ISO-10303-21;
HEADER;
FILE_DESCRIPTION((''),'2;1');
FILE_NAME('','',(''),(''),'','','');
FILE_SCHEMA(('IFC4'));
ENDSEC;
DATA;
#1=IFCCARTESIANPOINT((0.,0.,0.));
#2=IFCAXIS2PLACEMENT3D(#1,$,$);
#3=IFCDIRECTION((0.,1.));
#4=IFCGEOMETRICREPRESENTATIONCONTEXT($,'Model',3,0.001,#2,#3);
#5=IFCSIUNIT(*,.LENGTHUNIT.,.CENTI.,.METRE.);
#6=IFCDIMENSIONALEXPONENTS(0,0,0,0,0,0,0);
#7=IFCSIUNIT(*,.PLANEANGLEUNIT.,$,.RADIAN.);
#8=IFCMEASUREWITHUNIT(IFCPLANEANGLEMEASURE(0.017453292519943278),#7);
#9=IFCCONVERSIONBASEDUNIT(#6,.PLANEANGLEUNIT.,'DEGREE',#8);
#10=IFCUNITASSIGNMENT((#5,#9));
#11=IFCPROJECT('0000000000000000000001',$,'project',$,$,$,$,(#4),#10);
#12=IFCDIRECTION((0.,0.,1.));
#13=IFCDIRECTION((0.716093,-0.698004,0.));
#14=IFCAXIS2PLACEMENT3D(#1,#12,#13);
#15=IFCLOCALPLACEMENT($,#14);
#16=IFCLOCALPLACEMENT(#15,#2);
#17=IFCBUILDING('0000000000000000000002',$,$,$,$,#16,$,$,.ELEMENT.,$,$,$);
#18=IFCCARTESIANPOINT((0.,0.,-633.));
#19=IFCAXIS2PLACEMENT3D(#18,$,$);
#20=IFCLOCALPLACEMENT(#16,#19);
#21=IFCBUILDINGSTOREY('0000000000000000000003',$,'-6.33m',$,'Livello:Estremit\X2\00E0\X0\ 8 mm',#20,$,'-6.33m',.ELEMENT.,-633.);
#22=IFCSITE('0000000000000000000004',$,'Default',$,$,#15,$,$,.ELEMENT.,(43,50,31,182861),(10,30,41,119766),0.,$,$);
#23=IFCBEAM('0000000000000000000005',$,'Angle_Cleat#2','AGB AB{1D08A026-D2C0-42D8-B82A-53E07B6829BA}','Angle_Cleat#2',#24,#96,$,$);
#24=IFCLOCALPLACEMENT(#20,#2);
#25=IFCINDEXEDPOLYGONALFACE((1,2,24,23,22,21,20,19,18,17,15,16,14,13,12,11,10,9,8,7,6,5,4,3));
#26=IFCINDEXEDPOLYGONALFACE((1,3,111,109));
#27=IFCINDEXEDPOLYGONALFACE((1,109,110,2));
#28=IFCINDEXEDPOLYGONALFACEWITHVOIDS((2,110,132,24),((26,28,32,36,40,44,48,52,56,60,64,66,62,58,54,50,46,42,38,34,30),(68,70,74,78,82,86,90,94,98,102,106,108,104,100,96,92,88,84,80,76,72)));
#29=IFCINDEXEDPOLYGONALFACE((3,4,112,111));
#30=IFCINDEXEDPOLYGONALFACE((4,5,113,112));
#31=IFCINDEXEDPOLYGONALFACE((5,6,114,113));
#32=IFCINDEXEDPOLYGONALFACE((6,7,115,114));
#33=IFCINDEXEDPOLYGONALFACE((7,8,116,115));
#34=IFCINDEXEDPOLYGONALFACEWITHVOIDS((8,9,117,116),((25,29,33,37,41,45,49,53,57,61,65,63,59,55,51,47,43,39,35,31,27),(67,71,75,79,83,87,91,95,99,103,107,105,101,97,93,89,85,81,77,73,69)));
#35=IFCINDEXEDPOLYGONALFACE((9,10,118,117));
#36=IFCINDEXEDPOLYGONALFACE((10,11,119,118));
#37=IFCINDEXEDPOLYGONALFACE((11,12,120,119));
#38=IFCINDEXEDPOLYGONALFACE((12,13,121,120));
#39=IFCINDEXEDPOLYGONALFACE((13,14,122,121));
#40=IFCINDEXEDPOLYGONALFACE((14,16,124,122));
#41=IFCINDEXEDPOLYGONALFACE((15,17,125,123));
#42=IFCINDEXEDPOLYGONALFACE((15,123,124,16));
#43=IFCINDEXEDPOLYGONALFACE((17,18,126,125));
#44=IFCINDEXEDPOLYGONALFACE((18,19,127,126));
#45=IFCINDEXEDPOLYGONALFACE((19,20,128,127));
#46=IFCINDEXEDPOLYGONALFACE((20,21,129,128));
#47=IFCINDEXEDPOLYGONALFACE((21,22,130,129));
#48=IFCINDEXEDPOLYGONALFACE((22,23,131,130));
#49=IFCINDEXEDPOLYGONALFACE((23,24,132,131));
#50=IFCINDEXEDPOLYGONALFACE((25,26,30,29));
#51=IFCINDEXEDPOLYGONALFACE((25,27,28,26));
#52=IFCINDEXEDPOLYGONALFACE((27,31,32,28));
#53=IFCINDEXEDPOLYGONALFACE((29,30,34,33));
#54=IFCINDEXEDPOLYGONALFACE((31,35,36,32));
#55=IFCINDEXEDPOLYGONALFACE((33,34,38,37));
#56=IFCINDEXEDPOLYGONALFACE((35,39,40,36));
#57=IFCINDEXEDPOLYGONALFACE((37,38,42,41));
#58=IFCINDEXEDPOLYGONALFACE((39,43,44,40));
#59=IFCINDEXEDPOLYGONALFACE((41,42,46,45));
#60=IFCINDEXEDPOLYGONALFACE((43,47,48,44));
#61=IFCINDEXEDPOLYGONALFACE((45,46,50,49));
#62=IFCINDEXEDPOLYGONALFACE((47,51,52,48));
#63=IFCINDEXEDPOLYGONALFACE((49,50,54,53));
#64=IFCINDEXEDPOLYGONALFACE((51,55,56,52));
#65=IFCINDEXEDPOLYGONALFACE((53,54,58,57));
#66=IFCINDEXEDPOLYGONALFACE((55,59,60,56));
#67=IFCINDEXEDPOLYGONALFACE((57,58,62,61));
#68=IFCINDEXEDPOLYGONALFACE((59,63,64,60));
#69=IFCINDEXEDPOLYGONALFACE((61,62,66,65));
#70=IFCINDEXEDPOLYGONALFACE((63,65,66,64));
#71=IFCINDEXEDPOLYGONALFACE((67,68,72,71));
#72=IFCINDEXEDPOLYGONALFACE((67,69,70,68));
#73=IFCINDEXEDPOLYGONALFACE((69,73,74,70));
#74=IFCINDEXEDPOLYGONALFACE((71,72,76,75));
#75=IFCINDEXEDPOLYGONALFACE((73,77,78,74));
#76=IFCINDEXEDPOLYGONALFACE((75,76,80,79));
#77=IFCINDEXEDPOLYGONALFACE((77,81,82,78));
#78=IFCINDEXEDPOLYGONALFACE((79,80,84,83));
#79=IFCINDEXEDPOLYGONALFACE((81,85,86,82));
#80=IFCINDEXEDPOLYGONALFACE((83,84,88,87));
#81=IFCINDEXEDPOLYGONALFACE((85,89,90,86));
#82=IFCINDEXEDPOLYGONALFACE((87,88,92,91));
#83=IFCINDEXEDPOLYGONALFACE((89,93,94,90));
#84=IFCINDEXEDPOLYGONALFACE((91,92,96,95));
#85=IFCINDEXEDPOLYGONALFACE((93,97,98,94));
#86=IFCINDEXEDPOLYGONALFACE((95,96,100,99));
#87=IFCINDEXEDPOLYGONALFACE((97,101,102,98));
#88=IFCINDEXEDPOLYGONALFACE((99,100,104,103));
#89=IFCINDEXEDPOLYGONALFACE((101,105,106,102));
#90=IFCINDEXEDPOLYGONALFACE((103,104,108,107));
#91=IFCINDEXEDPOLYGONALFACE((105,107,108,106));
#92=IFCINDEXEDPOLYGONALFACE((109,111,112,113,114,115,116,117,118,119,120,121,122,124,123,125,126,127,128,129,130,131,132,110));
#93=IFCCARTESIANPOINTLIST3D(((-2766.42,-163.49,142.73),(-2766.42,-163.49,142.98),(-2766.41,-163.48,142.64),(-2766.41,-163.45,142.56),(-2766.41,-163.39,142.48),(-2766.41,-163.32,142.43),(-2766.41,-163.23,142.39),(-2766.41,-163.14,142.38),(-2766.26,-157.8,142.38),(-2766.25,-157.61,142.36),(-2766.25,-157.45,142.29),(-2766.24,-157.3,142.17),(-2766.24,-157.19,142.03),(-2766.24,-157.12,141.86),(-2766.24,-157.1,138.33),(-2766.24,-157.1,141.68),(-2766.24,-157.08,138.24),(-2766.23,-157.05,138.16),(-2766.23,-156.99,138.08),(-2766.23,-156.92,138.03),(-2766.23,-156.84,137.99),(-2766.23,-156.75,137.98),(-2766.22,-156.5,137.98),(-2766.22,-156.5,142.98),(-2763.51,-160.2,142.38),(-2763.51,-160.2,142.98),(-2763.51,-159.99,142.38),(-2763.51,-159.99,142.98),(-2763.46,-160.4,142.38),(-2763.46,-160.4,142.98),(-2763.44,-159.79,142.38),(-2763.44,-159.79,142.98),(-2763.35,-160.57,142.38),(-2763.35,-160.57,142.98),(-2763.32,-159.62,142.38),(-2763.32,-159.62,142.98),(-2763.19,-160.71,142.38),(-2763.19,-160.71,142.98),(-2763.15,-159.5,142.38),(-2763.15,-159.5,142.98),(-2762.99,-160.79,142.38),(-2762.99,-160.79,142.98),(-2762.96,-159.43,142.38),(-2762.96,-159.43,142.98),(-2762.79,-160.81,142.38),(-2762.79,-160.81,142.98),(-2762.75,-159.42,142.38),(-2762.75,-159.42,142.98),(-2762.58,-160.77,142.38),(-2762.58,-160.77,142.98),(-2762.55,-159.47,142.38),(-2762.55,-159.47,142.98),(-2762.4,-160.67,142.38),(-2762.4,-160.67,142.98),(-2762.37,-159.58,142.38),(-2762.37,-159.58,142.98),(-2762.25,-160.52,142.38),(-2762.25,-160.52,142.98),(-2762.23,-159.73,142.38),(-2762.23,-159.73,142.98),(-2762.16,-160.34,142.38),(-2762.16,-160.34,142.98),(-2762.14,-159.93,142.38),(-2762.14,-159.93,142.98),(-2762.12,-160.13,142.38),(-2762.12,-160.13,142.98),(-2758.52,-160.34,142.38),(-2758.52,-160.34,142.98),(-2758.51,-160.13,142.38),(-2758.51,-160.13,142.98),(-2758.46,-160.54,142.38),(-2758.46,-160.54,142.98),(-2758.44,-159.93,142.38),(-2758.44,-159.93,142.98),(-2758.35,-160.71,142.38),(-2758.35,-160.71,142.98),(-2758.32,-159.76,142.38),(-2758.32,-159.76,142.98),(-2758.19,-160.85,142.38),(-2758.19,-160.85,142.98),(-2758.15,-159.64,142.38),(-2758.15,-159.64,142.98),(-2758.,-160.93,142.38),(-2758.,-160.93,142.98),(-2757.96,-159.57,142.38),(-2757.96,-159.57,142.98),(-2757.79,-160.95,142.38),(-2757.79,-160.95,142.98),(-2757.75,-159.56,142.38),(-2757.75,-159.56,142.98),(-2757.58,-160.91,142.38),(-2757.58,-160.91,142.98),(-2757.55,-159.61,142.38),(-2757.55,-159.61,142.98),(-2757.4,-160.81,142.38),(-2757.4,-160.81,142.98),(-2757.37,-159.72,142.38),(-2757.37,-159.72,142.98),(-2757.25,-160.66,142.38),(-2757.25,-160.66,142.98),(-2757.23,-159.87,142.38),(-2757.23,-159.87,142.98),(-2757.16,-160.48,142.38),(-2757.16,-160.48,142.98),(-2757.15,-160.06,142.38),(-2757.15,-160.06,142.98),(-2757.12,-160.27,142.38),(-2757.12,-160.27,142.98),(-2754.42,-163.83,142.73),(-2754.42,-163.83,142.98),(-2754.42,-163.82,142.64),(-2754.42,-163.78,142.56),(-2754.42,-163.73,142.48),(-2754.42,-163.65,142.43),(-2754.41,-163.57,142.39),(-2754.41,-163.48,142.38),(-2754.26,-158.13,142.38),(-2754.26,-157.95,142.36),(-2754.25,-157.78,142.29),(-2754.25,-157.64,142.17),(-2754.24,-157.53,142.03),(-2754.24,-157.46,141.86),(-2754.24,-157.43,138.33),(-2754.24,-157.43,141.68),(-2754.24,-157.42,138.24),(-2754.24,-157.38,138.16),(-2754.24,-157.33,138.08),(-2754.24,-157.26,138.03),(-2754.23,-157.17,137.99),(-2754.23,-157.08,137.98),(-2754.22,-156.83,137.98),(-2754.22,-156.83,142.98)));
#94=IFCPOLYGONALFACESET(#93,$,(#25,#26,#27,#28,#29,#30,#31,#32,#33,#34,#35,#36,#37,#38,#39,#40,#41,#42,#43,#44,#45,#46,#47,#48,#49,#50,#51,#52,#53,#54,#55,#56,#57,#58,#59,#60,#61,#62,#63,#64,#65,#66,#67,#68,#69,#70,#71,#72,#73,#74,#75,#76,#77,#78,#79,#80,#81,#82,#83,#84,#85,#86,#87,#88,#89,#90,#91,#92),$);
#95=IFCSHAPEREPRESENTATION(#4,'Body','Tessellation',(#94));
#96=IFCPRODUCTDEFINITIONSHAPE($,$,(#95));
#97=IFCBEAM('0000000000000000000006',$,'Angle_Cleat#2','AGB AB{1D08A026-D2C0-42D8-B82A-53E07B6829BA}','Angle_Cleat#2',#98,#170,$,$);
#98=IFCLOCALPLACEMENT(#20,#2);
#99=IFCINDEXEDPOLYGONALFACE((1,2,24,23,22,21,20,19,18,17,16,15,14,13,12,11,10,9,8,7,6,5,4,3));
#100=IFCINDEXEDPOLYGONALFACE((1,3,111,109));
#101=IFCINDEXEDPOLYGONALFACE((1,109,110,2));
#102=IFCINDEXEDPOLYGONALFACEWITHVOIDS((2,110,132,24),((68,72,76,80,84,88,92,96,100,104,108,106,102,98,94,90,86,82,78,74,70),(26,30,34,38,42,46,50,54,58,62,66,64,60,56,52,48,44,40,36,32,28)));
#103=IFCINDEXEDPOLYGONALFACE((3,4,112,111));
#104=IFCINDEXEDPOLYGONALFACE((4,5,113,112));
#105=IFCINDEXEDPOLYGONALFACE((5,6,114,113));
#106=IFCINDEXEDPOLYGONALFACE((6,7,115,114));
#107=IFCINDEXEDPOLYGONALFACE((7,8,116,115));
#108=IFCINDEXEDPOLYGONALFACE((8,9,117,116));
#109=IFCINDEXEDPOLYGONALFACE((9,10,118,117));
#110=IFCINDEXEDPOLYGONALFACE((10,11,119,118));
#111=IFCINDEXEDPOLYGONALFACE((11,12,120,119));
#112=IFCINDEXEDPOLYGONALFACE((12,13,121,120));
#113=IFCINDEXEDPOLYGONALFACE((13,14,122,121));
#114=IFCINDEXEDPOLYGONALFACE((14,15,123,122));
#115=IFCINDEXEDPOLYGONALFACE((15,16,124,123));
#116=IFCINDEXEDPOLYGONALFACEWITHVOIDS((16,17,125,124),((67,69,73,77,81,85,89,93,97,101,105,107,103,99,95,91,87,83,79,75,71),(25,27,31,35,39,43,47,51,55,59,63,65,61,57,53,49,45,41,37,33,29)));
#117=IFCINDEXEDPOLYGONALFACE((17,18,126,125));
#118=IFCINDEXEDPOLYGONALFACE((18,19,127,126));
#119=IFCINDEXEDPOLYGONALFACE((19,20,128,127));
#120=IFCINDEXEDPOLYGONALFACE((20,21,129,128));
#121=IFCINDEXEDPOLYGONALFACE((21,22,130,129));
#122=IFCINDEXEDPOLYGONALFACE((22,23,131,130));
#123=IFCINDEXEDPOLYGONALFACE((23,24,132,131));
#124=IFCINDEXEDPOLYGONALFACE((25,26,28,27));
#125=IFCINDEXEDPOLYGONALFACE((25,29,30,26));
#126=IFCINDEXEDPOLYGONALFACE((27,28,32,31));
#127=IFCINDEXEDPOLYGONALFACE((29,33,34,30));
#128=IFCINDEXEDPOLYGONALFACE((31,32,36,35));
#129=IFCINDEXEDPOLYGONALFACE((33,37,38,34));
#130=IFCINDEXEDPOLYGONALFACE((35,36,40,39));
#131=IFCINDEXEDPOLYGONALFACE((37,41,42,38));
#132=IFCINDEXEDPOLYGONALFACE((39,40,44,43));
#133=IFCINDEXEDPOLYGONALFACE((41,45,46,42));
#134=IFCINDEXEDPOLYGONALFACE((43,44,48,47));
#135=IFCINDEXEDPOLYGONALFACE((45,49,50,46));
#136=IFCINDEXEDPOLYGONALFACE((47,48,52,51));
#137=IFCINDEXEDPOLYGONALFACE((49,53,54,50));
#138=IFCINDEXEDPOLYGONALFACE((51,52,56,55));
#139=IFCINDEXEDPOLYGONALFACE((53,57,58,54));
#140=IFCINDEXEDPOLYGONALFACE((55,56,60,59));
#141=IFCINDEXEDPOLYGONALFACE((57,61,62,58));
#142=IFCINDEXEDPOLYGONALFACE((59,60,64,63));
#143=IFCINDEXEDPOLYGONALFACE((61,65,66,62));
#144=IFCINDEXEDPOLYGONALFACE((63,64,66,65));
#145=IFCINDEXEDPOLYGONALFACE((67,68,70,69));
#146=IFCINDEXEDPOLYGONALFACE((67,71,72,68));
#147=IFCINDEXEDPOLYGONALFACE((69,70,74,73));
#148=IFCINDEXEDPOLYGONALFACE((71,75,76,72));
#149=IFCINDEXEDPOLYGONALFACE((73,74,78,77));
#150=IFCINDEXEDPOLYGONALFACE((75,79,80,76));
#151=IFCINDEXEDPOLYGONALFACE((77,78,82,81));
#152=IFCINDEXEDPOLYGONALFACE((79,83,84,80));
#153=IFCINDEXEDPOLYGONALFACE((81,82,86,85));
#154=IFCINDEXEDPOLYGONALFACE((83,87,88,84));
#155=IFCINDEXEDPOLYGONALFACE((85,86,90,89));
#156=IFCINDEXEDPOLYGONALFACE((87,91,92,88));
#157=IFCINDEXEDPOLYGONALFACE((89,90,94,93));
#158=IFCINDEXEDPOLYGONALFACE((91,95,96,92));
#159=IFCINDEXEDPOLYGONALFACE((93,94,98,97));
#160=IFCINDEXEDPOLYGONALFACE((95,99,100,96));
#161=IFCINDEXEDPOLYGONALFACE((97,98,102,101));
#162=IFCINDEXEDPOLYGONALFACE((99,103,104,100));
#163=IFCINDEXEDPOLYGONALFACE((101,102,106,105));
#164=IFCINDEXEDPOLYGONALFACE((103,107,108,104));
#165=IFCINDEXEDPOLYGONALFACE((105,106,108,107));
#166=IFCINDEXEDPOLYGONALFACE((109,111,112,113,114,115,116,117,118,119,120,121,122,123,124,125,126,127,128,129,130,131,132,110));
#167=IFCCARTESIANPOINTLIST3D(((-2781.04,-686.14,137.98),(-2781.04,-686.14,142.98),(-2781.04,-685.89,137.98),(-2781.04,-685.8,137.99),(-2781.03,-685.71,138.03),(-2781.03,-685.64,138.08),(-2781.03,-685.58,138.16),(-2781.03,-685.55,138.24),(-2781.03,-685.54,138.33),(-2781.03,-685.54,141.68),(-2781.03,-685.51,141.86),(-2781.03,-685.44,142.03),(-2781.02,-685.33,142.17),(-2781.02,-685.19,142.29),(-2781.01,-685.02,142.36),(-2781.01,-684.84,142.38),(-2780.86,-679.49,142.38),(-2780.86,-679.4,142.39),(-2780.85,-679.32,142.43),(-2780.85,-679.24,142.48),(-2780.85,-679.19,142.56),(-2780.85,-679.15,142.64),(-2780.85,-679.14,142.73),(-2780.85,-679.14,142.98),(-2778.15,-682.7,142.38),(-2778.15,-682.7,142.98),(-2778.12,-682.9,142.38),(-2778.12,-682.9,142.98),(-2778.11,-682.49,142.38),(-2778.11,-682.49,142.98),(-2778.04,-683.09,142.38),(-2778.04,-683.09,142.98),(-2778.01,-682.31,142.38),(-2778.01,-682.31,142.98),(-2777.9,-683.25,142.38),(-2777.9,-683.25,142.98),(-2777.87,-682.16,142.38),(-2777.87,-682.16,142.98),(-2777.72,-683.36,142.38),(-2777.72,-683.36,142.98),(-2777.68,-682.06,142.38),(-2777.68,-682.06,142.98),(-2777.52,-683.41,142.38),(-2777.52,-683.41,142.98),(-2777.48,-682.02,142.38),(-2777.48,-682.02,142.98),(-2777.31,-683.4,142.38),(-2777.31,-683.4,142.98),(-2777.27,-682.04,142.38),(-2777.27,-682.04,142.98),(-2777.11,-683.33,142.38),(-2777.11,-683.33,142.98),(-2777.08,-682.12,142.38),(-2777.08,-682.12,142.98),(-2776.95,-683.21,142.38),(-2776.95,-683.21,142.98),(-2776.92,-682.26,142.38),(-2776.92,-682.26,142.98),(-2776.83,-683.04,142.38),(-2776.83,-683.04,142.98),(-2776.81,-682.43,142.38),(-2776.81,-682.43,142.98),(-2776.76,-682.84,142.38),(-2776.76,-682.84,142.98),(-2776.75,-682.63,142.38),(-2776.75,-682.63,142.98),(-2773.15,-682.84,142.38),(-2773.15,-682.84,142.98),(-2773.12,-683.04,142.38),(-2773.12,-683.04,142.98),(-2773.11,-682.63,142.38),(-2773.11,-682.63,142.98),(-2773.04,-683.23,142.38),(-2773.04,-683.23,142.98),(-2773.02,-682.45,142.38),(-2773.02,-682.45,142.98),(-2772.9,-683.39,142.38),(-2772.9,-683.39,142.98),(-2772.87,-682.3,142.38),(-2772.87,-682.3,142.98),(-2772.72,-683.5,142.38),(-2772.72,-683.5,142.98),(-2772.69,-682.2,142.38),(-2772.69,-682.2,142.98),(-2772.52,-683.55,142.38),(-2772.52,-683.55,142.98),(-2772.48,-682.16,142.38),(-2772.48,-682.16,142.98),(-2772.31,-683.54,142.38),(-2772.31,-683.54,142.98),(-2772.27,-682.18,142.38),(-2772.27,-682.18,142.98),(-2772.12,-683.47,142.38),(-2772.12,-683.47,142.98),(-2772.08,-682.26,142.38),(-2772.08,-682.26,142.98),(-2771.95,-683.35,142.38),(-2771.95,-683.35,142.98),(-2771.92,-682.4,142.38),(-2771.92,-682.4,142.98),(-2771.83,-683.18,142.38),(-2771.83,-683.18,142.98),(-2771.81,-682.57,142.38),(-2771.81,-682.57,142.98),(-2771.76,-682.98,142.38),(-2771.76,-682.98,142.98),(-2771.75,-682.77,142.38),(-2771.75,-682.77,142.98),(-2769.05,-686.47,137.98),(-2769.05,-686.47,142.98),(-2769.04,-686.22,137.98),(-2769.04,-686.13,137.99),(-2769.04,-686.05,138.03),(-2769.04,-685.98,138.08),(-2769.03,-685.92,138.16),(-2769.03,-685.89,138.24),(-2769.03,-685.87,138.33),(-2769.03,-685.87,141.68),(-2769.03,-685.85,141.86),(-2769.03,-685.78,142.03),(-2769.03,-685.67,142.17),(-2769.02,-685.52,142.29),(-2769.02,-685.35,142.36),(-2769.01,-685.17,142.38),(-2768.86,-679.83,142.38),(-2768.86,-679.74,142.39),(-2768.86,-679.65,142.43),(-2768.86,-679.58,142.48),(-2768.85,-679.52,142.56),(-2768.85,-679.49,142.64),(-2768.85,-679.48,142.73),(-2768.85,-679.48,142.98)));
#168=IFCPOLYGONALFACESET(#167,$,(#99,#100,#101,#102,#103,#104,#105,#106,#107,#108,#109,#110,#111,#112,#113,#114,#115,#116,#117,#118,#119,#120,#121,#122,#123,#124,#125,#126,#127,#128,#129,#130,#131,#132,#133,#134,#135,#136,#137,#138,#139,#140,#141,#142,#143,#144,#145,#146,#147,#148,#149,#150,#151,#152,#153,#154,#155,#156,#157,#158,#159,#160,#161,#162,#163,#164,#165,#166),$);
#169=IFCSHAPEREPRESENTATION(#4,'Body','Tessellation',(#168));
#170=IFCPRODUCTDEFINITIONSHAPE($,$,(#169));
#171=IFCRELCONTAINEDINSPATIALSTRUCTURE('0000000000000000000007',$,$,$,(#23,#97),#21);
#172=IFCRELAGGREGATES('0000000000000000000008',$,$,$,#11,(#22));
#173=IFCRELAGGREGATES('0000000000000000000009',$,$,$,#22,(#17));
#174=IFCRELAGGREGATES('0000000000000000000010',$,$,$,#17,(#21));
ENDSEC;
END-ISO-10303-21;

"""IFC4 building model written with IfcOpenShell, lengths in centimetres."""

from ifc_helpers import new_model, entity, si_unit, converted_unit, direction, frame, frame_2d, origin, place, context, project, spatial, circle, l_section, extrude, element, save


model = new_model("IFC4")

# Units and contexts
model_context = context("Model", 3, precision=0.001, world=origin(), true_north=direction((0.0, 1.0)))
ifc_project = project(units=[si_unit("LENGTHUNIT", "METRE", prefix="CENTI"), converted_unit("PLANEANGLEUNIT", "DEGREE", entity("IfcPlaneAngleMeasure", 0.017453292519943278), si_unit("PLANEANGLEUNIT", "RADIAN"), dimensions=[0, 0, 0, 0, 0, 0, 0])], contexts=[model_context])

# Site, building, storey
site_placement = place(None, frame((0.0, 0.0, 0.0), z_axis=(0.0, 0.0, 1.0), x_axis=(0.716093, -0.698004, 0.0)))
site = spatial("IfcSite", under=ifc_project, at=site_placement, Name="Default", CompositionType="ELEMENT", RefLatitude=(43, 50, 31, 182861), RefLongitude=(10, 30, 41, 119766), RefElevation=0.0)
building_placement = place(site_placement, origin())
building = spatial("IfcBuilding", under=site, at=building_placement, CompositionType="ELEMENT")
storey_placement = place(building_placement, frame((0.0, 0.0, -633.0)))
storey = spatial("IfcBuildingStorey", under=building, at=storey_placement, Name="-6.33m", ObjectType="Livello:Estremità 8 mm", LongName="-6.33m", CompositionType="ELEMENT", Elevation=-633.0)

# Beams, openings
beam_1_placement = place(storey_placement, frame((-2754.29, -159.08, 141.75), z_axis=(0.999608, -0.02798, 0.0), x_axis=(-0.02798, -0.999608, 0.0)))
beam_1 = element("IfcBeam", 1, at=beam_1_placement, inside=storey, Name="Angle_Cleat#2", Description="AGB AB{1D08A026-D2C0-42D8-B82A-53E07B6829BA}", ObjectType="Angle_Cleat#2", context=model_context, shape_type="SweptSolid", body=[
    extrude(l_section(Depth=5.0, Width=7.0, Thickness=0.6, FilletRadius=0.7, EdgeRadius=0.35, at=frame_2d((1.25, 1.27))), origin(), (0.0, 0.0, -1.0), 12.0),
])
opening_1_placement = place(beam_1_placement, frame((1.27, -0.6, -6.0), z_axis=(0.0, -1.0, 0.0), x_axis=(0.0, 0.0, 1.0)))
element("IfcOpeningElement", 2, at=opening_1_placement, cuts=beam_1, ObjectType="Opening", context=model_context, shape_type="SweptSolid", body=[
    extrude(circle(Radius=0.7, at=frame_2d((2.5, 0.0), x_axis=(1.0, 0.0))), origin(), (0.0, 0.0, 1.0), 0.7),
])
opening_2_placement = place(beam_1_placement, frame((1.27, -0.6, -6.0), z_axis=(0.0, -1.0, 0.0), x_axis=(0.0, 0.0, 1.0)))
element("IfcOpeningElement", 3, at=opening_2_placement, cuts=beam_1, ObjectType="Opening", context=model_context, shape_type="SweptSolid", body=[
    extrude(circle(Radius=0.7, at=frame_2d((-2.5, 0.0), x_axis=(1.0, 0.0))), origin(), (0.0, 0.0, 1.0), 0.7),
])
beam_2_placement = place(storey_placement, frame((-2780.98, -683.89, 141.75), z_axis=(-0.999608, 0.02798, 0.0), x_axis=(0.02798, 0.999608, 0.0)))
beam_2 = element("IfcBeam", 4, at=beam_2_placement, inside=storey, Name="Angle_Cleat#2", Description="AGB AB{1D08A026-D2C0-42D8-B82A-53E07B6829BA}", ObjectType="Angle_Cleat#2", context=model_context, shape_type="SweptSolid", body=[
    extrude(l_section(Depth=5.0, Width=7.0, Thickness=0.6, FilletRadius=0.7, EdgeRadius=0.35, at=frame_2d((1.25, 1.27))), origin(), (0.0, 0.0, -1.0), 12.0),
])
opening_3_placement = place(beam_2_placement, frame((1.27, -0.6, -6.0), z_axis=(0.0, -1.0, 0.0), x_axis=(0.0, 0.0, 1.0)))
element("IfcOpeningElement", 5, at=opening_3_placement, cuts=beam_2, ObjectType="Opening", context=model_context, shape_type="SweptSolid", body=[
    extrude(circle(Radius=0.7, at=frame_2d((2.5, 0.0), x_axis=(1.0, 0.0))), origin(), (0.0, 0.0, 1.0), 0.7),
])
opening_4_placement = place(beam_2_placement, frame((1.27, -0.6, -6.0), z_axis=(0.0, -1.0, 0.0), x_axis=(0.0, 0.0, 1.0)))
element("IfcOpeningElement", 6, at=opening_4_placement, cuts=beam_2, ObjectType="Opening", context=model_context, shape_type="SweptSolid", body=[
    extrude(circle(Radius=0.7, at=frame_2d((-2.5, 0.0), x_axis=(1.0, 0.0))), origin(), (0.0, 0.0, 1.0), 0.7),
])

save(model, "model.ifc")
